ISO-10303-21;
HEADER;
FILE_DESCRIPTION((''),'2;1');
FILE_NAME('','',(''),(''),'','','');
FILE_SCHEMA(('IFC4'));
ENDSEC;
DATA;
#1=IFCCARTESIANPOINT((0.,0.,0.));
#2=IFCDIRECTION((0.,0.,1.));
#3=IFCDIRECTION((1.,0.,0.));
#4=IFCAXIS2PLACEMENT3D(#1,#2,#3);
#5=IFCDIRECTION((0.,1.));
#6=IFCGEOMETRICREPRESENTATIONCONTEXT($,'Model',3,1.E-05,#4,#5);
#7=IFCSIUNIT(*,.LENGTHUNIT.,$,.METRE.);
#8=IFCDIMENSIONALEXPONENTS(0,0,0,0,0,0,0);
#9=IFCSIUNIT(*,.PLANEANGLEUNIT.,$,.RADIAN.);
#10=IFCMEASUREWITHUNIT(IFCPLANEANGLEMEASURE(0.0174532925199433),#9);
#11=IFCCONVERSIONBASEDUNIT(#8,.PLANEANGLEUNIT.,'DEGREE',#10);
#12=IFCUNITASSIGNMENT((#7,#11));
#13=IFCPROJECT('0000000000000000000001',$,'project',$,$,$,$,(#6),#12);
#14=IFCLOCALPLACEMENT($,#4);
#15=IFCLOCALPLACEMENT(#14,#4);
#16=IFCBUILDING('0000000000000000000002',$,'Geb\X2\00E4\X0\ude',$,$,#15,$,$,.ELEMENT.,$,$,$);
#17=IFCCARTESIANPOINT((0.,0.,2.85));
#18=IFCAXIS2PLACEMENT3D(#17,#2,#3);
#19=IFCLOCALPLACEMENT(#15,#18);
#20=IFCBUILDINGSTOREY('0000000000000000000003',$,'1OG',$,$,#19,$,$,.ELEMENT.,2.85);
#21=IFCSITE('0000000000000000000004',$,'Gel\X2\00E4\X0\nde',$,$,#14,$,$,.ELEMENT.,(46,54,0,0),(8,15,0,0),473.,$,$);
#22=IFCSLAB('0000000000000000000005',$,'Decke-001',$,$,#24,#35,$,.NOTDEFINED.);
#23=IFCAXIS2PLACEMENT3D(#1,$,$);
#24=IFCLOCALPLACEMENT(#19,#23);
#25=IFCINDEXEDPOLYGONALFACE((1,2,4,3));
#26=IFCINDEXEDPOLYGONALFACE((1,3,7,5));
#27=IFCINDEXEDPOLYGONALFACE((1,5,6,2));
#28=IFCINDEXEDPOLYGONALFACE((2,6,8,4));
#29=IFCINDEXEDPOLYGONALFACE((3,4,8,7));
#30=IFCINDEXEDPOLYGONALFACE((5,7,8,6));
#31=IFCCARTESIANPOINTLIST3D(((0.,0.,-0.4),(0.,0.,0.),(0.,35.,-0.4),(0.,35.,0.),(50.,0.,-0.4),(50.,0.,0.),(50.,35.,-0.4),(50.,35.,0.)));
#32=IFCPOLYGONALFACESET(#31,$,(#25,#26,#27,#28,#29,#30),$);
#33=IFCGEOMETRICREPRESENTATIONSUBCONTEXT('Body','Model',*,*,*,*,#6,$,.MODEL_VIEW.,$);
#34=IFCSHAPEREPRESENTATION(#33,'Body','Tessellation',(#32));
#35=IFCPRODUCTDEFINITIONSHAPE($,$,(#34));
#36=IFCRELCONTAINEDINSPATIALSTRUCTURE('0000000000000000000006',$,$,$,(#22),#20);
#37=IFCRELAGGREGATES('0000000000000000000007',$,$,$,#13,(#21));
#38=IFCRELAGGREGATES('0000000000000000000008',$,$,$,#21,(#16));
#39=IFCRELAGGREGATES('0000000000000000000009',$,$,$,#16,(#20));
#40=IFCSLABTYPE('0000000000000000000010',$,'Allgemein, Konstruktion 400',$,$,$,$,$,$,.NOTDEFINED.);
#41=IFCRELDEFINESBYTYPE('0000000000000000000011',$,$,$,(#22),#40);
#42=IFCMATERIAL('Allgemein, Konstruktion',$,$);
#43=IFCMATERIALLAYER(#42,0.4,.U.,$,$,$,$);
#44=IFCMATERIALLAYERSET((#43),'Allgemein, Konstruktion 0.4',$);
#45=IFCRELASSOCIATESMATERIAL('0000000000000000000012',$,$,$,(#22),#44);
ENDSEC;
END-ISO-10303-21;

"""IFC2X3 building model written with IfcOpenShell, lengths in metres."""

from ifc_helpers import new_model, entity, si_unit, converted_unit, direction, frame, origin_with_axes, place, context, subcontext, project, spatial, polyline, outline, extrude, material, layer, layer_set, layer_usage, type_object, element, save


model = new_model("IFC2X3")

# Units and contexts
model_context = context("Model", 3, precision=1e-05, world=origin_with_axes(), true_north=direction((0.0, 1.0)))
body_context = subcontext(model_context, "Body", "Model", "MODEL_VIEW")
ifc_project = project(units=[si_unit("LENGTHUNIT", "METRE"), converted_unit("PLANEANGLEUNIT", "DEGREE", entity("IfcPlaneAngleMeasure", 0.0174532925199433), si_unit("PLANEANGLEUNIT", "RADIAN"), dimensions=[0, 0, 0, 0, 0, 0, 0])], contexts=[model_context])

# Site, building, storey
site_placement = place(None, origin_with_axes())
site = spatial("IfcSite", under=ifc_project, at=site_placement, Name="Gelände", CompositionType="ELEMENT", RefLatitude=(46, 54, 0, 0), RefLongitude=(8, 15, 0, 0), RefElevation=473.0)
building_placement = place(site_placement, origin_with_axes())
building = spatial("IfcBuilding", under=site, at=building_placement, Name="Gebäude", CompositionType="ELEMENT")
storey_placement = place(building_placement, frame((0.0, 0.0, 2.85), z_axis=(0.0, 0.0, 1.0), x_axis=(1.0, 0.0, 0.0)))
storey = spatial("IfcBuildingStorey", under=building, at=storey_placement, Name="1OG", CompositionType="ELEMENT", Elevation=2.85)

# Slab
ifc_material = material(Name="Allgemein, Konstruktion")
ifc_layer = layer(ifc_material, 0.4, ventilated="UNKNOWN")
ifc_layer_set = layer_set([ifc_layer], Name="Allgemein, Konstruktion 0.4")
ifc_layer_usage = layer_usage(ifc_layer_set, "AXIS3", "NEGATIVE", 0.4)
slab_type = type_object("IfcSlabType", Name="Allgemein, Konstruktion 400", PredefinedType="NOTDEFINED")
slab_placement = place(storey_placement, origin_with_axes())
element("IfcSlab", 1, at=slab_placement, inside=storey, type_object=slab_type, material=ifc_layer_usage, Name="Decke-001", PredefinedType="NOTDEFINED", context=body_context, shape_type="SweptSolid", body=[
    extrude(outline(polyline([(0.0, 0.0), (50.0, 0.0), (50.0, 35.0), (0.0, 35.0), (0.0, 0.0)])), frame((0.0, 0.0, -0.4), z_axis=(0.0, 0.0, 1.0), x_axis=(1.0, 0.0, 0.0)), (0.0, 0.0, 1.0), 0.4),
])

save(model, "model.ifc")
